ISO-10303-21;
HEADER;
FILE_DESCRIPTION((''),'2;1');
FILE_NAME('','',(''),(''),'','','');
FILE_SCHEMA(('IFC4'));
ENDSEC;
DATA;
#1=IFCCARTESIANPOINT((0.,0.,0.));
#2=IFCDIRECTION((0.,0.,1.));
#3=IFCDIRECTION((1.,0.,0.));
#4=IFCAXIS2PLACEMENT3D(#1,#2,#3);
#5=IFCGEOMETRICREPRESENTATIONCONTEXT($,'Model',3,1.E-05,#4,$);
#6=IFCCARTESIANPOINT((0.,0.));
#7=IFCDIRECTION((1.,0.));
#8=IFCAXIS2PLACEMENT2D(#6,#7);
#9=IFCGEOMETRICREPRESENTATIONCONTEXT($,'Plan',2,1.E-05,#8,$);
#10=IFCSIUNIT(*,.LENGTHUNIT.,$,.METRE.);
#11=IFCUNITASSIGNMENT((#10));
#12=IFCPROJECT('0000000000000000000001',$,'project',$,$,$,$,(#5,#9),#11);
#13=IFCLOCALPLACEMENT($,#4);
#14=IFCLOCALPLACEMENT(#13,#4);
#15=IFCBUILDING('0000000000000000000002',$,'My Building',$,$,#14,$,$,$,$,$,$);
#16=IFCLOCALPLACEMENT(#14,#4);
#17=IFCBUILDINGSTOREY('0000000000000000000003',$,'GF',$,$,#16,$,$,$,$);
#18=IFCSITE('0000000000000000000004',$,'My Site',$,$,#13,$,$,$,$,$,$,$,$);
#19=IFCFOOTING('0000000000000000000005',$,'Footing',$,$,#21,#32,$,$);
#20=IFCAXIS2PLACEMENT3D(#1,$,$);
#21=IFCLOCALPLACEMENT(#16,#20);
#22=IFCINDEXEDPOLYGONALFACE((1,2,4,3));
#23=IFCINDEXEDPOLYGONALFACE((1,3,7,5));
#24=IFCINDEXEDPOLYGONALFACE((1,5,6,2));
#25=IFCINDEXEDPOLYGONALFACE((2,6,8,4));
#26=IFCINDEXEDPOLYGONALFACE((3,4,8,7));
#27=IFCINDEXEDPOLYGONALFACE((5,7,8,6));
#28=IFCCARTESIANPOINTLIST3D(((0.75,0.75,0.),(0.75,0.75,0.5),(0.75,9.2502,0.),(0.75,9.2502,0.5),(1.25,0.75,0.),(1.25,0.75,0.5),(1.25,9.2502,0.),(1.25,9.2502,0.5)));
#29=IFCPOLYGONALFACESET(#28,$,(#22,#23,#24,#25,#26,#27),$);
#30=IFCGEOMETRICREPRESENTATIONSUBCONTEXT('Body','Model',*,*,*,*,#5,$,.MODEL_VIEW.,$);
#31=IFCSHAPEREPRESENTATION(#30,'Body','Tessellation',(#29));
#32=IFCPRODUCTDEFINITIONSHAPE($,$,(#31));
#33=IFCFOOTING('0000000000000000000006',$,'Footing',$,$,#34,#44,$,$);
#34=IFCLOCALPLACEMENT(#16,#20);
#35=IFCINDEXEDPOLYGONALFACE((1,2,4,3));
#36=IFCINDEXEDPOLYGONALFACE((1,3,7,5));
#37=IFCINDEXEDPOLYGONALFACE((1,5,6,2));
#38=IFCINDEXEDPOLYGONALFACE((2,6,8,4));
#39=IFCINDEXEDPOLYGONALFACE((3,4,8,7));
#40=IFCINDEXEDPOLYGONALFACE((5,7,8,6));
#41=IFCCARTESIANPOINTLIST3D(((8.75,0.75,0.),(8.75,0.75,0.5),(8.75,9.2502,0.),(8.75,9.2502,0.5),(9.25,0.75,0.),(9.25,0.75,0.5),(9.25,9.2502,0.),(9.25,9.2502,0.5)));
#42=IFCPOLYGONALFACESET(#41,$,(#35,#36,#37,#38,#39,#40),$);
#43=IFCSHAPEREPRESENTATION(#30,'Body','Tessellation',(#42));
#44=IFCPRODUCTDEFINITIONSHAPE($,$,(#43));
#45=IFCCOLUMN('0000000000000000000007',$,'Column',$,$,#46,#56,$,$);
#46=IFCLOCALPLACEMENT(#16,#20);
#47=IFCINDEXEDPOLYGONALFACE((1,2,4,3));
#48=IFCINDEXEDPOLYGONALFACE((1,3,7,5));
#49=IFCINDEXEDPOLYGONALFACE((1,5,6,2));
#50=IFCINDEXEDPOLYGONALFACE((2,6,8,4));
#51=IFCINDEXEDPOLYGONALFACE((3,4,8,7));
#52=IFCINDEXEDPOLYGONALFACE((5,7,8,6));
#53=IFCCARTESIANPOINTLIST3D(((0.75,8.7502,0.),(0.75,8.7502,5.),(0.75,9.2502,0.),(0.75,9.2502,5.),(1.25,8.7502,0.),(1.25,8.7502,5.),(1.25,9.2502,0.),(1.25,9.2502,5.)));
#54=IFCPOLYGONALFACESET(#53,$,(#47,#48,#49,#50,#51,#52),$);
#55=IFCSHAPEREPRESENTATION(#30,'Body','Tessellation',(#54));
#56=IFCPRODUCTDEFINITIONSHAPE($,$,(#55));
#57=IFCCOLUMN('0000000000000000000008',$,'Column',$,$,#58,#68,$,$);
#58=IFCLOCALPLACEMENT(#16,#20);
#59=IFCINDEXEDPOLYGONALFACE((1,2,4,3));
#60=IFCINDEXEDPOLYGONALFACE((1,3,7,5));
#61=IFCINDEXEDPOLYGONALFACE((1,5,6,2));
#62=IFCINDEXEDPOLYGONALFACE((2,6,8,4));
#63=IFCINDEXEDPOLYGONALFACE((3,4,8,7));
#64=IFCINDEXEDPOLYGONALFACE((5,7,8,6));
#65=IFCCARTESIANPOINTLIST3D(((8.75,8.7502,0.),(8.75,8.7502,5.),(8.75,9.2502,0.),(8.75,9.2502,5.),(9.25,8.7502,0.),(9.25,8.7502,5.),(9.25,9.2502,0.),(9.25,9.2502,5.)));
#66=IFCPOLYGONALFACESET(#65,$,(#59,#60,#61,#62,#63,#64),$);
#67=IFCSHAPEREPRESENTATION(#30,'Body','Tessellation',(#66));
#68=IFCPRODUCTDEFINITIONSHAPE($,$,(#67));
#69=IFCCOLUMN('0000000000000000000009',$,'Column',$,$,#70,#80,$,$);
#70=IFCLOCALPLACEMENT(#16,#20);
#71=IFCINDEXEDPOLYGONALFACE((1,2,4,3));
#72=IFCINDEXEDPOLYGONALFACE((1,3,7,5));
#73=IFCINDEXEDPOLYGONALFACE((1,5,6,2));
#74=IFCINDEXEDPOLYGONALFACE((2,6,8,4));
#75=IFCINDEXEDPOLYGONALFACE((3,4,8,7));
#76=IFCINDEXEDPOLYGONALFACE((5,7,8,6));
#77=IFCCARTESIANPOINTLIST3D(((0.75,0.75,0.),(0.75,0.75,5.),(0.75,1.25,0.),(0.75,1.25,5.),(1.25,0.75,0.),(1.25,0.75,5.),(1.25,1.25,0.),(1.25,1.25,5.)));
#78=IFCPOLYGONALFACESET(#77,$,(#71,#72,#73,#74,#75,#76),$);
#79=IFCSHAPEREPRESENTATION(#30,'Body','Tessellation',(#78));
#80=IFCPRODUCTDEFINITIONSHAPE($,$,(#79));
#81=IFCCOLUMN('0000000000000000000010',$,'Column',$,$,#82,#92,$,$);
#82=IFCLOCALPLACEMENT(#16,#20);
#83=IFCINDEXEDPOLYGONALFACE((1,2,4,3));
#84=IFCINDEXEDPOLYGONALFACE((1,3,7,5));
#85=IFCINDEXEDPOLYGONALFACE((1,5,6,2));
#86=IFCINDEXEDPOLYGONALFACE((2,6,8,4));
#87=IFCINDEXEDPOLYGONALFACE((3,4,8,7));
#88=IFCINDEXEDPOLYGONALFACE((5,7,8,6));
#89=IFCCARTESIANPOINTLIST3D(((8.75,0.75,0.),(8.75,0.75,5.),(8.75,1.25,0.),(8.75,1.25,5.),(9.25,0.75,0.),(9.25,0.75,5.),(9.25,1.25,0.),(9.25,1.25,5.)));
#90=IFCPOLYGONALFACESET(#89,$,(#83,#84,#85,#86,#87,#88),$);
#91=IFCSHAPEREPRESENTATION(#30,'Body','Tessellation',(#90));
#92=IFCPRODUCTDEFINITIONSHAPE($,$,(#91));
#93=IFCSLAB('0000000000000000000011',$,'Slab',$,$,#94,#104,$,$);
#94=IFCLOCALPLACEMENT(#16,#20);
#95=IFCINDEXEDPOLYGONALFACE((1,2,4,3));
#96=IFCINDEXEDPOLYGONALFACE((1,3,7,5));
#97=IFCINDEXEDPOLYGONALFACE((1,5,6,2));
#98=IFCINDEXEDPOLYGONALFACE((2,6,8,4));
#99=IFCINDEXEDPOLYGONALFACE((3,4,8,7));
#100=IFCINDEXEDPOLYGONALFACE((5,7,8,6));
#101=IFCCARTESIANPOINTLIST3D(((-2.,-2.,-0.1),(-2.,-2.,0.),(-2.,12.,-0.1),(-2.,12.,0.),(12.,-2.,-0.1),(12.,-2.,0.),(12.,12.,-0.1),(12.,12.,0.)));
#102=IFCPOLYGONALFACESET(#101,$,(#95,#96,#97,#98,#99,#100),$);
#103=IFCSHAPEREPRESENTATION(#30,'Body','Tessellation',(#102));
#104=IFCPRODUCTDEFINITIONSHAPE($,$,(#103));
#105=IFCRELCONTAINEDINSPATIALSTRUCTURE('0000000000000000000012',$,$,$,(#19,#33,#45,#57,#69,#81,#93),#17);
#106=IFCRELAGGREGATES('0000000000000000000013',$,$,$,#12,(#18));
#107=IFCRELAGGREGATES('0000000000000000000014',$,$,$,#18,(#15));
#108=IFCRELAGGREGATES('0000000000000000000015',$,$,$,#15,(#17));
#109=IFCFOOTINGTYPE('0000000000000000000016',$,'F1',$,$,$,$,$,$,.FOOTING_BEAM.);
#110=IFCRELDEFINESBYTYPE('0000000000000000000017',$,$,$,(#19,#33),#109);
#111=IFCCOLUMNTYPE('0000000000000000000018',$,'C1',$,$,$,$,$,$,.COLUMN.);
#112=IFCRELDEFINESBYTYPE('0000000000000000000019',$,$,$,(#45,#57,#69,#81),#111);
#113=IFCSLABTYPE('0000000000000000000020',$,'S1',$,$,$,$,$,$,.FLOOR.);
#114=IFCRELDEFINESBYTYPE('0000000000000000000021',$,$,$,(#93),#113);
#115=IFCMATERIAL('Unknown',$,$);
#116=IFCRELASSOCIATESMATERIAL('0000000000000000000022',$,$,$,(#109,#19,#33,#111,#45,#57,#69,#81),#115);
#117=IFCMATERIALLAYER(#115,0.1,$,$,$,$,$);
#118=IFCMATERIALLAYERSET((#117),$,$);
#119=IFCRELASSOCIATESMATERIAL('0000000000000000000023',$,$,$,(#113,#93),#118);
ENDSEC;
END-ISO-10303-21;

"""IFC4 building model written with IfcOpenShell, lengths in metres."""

from ifc_helpers import new_model, si_unit, frame, origin_with_axes, origin_2d_with_axis, place, context, subcontext, project, spatial, indexed_curve, rectangle, outline, extrude, material, layer, layer_set, layer_usage, material_profile, profile_set, profile_usage, type_object, element, save


model = new_model("IFC4")

# Units and contexts
model_context = context("Model", 3, precision=1e-05, world=origin_with_axes())
plan_context = context("Plan", 2, precision=1e-05, world=origin_2d_with_axis())
body_context_1 = subcontext(model_context, "Body", "Model", "MODEL_VIEW")
ifc_project = project(units=[si_unit("LENGTHUNIT", "METRE")], contexts=[model_context, plan_context])

# Site, building, storey
site_placement = place(None, origin_with_axes())
site = spatial("IfcSite", under=ifc_project, at=site_placement, Name="My Site")
building_placement = place(site_placement, origin_with_axes())
building = spatial("IfcBuilding", under=site, at=building_placement, Name="My Building")
storey_placement = place(building_placement, origin_with_axes())
storey = spatial("IfcBuildingStorey", under=building, at=storey_placement, Name="GF")

# Footings
ifc_material = material(Name="Unknown")
ifc_material_profile_1 = material_profile(ifc_material, rectangle(XDim=0.5, YDim=0.5))
ifc_profile_set_1 = profile_set([ifc_material_profile_1])
ifc_profile_usage_1 = profile_usage(ifc_profile_set_1, cardinal=5)
footing_type = type_object("IfcFootingType", Name="F1", PredefinedType="FOOTING_BEAM", material=ifc_profile_set_1)
footing_1_placement = place(storey_placement, frame((1.0, 9.2502, 0.25), z_axis=(0.0, -1.0, 0.0), x_axis=(1.0, 0.0, 0.0)))
element("IfcFooting", 1, at=footing_1_placement, inside=storey, type_object=footing_type, material=ifc_profile_usage_1, Name="Footing", context=body_context_1, shape_type="SweptSolid", body=[
    extrude(rectangle(XDim=0.5, YDim=0.5), origin_with_axes(), (0.0, 0.0, 1.0), 8.5002),
])
ifc_profile_usage_2 = profile_usage(ifc_profile_set_1, cardinal=5)
footing_2_placement = place(storey_placement, frame((9.0, 9.2502, 0.25), z_axis=(0.0, -1.0, 0.0), x_axis=(1.0, 0.0, 0.0)))
element("IfcFooting", 2, at=footing_2_placement, inside=storey, type_object=footing_type, material=ifc_profile_usage_2, Name="Footing", context=body_context_1, shape_type="SweptSolid", body=[
    extrude(rectangle(XDim=0.5, YDim=0.5), origin_with_axes(), (0.0, 0.0, 1.0), 8.5002),
])

# Columns
ifc_material_profile_2 = material_profile(ifc_material, rectangle(XDim=0.5, YDim=0.5))
ifc_profile_set_2 = profile_set([ifc_material_profile_2])
ifc_profile_usage_3 = profile_usage(ifc_profile_set_2, cardinal=5)
column_type = type_object("IfcColumnType", Name="C1", PredefinedType="COLUMN", material=ifc_profile_set_2)
column_1_placement = place(storey_placement, frame((1.0, 9.0002, 0.0), z_axis=(0.0, 0.0, 1.0), x_axis=(1.0, 0.0, 0.0)))
element("IfcColumn", 3, at=column_1_placement, inside=storey, type_object=column_type, material=ifc_profile_usage_3, Name="Column", context=body_context_1, shape_type="SweptSolid", body=[
    extrude(rectangle(XDim=0.5, YDim=0.5), origin_with_axes(), (0.0, 0.0, 1.0), 5.0),
])
ifc_profile_usage_4 = profile_usage(ifc_profile_set_2, cardinal=5)
column_2_placement = place(storey_placement, frame((9.0, 9.0002, 0.0), z_axis=(0.0, 0.0, 1.0), x_axis=(1.0, 0.0, 0.0)))
element("IfcColumn", 4, at=column_2_placement, inside=storey, type_object=column_type, material=ifc_profile_usage_4, Name="Column", context=body_context_1, shape_type="SweptSolid", body=[
    extrude(rectangle(XDim=0.5, YDim=0.5), origin_with_axes(), (0.0, 0.0, 1.0), 5.0),
])
ifc_profile_usage_5 = profile_usage(ifc_profile_set_2, cardinal=5)
column_3_placement = place(storey_placement, frame((1.0, 1.0, 0.0), z_axis=(0.0, 0.0, 1.0), x_axis=(1.0, 0.0, 0.0)))
element("IfcColumn", 5, at=column_3_placement, inside=storey, type_object=column_type, material=ifc_profile_usage_5, Name="Column", context=body_context_1, shape_type="SweptSolid", body=[
    extrude(rectangle(XDim=0.5, YDim=0.5), origin_with_axes(), (0.0, 0.0, 1.0), 5.0),
])
ifc_profile_usage_6 = profile_usage(ifc_profile_set_2, cardinal=5)
column_4_placement = place(storey_placement, frame((9.0, 1.0, 0.0), z_axis=(0.0, 0.0, 1.0), x_axis=(1.0, 0.0, 0.0)))
element("IfcColumn", 6, at=column_4_placement, inside=storey, type_object=column_type, material=ifc_profile_usage_6, Name="Column", context=body_context_1, shape_type="SweptSolid", body=[
    extrude(rectangle(XDim=0.5, YDim=0.5), origin_with_axes(), (0.0, 0.0, 1.0), 5.0),
])

# Slab
ifc_layer_1 = layer(ifc_material, 0.1)
ifc_layer_set_1 = layer_set([ifc_layer_1])
ifc_layer_usage_1 = layer_usage(ifc_layer_set_1, "AXIS3", "POSITIVE", -0.1)
slab_type = type_object("IfcSlabType", Name="S1", PredefinedType="FLOOR", material=ifc_layer_set_1)
slab_placement = place(storey_placement, origin_with_axes())
element("IfcSlab", 7, at=slab_placement, inside=storey, type_object=slab_type, material=ifc_layer_usage_1, Name="Slab", context=body_context_1, shape_type="SweptSolid", body=[
    extrude(outline(indexed_curve([(12.0, -2.0), (12.0, 12.0), (-2.0, 12.0), (-2.0, -2.0), (12.0, -2.0)])), frame((0.0, 0.0, -0.1), z_axis=(0.0, 0.0, 1.0), x_axis=(1.0, 0.0, 0.0)), (0.0, 0.0, 1.0), 0.1),
])

save(model, "model.ifc")
